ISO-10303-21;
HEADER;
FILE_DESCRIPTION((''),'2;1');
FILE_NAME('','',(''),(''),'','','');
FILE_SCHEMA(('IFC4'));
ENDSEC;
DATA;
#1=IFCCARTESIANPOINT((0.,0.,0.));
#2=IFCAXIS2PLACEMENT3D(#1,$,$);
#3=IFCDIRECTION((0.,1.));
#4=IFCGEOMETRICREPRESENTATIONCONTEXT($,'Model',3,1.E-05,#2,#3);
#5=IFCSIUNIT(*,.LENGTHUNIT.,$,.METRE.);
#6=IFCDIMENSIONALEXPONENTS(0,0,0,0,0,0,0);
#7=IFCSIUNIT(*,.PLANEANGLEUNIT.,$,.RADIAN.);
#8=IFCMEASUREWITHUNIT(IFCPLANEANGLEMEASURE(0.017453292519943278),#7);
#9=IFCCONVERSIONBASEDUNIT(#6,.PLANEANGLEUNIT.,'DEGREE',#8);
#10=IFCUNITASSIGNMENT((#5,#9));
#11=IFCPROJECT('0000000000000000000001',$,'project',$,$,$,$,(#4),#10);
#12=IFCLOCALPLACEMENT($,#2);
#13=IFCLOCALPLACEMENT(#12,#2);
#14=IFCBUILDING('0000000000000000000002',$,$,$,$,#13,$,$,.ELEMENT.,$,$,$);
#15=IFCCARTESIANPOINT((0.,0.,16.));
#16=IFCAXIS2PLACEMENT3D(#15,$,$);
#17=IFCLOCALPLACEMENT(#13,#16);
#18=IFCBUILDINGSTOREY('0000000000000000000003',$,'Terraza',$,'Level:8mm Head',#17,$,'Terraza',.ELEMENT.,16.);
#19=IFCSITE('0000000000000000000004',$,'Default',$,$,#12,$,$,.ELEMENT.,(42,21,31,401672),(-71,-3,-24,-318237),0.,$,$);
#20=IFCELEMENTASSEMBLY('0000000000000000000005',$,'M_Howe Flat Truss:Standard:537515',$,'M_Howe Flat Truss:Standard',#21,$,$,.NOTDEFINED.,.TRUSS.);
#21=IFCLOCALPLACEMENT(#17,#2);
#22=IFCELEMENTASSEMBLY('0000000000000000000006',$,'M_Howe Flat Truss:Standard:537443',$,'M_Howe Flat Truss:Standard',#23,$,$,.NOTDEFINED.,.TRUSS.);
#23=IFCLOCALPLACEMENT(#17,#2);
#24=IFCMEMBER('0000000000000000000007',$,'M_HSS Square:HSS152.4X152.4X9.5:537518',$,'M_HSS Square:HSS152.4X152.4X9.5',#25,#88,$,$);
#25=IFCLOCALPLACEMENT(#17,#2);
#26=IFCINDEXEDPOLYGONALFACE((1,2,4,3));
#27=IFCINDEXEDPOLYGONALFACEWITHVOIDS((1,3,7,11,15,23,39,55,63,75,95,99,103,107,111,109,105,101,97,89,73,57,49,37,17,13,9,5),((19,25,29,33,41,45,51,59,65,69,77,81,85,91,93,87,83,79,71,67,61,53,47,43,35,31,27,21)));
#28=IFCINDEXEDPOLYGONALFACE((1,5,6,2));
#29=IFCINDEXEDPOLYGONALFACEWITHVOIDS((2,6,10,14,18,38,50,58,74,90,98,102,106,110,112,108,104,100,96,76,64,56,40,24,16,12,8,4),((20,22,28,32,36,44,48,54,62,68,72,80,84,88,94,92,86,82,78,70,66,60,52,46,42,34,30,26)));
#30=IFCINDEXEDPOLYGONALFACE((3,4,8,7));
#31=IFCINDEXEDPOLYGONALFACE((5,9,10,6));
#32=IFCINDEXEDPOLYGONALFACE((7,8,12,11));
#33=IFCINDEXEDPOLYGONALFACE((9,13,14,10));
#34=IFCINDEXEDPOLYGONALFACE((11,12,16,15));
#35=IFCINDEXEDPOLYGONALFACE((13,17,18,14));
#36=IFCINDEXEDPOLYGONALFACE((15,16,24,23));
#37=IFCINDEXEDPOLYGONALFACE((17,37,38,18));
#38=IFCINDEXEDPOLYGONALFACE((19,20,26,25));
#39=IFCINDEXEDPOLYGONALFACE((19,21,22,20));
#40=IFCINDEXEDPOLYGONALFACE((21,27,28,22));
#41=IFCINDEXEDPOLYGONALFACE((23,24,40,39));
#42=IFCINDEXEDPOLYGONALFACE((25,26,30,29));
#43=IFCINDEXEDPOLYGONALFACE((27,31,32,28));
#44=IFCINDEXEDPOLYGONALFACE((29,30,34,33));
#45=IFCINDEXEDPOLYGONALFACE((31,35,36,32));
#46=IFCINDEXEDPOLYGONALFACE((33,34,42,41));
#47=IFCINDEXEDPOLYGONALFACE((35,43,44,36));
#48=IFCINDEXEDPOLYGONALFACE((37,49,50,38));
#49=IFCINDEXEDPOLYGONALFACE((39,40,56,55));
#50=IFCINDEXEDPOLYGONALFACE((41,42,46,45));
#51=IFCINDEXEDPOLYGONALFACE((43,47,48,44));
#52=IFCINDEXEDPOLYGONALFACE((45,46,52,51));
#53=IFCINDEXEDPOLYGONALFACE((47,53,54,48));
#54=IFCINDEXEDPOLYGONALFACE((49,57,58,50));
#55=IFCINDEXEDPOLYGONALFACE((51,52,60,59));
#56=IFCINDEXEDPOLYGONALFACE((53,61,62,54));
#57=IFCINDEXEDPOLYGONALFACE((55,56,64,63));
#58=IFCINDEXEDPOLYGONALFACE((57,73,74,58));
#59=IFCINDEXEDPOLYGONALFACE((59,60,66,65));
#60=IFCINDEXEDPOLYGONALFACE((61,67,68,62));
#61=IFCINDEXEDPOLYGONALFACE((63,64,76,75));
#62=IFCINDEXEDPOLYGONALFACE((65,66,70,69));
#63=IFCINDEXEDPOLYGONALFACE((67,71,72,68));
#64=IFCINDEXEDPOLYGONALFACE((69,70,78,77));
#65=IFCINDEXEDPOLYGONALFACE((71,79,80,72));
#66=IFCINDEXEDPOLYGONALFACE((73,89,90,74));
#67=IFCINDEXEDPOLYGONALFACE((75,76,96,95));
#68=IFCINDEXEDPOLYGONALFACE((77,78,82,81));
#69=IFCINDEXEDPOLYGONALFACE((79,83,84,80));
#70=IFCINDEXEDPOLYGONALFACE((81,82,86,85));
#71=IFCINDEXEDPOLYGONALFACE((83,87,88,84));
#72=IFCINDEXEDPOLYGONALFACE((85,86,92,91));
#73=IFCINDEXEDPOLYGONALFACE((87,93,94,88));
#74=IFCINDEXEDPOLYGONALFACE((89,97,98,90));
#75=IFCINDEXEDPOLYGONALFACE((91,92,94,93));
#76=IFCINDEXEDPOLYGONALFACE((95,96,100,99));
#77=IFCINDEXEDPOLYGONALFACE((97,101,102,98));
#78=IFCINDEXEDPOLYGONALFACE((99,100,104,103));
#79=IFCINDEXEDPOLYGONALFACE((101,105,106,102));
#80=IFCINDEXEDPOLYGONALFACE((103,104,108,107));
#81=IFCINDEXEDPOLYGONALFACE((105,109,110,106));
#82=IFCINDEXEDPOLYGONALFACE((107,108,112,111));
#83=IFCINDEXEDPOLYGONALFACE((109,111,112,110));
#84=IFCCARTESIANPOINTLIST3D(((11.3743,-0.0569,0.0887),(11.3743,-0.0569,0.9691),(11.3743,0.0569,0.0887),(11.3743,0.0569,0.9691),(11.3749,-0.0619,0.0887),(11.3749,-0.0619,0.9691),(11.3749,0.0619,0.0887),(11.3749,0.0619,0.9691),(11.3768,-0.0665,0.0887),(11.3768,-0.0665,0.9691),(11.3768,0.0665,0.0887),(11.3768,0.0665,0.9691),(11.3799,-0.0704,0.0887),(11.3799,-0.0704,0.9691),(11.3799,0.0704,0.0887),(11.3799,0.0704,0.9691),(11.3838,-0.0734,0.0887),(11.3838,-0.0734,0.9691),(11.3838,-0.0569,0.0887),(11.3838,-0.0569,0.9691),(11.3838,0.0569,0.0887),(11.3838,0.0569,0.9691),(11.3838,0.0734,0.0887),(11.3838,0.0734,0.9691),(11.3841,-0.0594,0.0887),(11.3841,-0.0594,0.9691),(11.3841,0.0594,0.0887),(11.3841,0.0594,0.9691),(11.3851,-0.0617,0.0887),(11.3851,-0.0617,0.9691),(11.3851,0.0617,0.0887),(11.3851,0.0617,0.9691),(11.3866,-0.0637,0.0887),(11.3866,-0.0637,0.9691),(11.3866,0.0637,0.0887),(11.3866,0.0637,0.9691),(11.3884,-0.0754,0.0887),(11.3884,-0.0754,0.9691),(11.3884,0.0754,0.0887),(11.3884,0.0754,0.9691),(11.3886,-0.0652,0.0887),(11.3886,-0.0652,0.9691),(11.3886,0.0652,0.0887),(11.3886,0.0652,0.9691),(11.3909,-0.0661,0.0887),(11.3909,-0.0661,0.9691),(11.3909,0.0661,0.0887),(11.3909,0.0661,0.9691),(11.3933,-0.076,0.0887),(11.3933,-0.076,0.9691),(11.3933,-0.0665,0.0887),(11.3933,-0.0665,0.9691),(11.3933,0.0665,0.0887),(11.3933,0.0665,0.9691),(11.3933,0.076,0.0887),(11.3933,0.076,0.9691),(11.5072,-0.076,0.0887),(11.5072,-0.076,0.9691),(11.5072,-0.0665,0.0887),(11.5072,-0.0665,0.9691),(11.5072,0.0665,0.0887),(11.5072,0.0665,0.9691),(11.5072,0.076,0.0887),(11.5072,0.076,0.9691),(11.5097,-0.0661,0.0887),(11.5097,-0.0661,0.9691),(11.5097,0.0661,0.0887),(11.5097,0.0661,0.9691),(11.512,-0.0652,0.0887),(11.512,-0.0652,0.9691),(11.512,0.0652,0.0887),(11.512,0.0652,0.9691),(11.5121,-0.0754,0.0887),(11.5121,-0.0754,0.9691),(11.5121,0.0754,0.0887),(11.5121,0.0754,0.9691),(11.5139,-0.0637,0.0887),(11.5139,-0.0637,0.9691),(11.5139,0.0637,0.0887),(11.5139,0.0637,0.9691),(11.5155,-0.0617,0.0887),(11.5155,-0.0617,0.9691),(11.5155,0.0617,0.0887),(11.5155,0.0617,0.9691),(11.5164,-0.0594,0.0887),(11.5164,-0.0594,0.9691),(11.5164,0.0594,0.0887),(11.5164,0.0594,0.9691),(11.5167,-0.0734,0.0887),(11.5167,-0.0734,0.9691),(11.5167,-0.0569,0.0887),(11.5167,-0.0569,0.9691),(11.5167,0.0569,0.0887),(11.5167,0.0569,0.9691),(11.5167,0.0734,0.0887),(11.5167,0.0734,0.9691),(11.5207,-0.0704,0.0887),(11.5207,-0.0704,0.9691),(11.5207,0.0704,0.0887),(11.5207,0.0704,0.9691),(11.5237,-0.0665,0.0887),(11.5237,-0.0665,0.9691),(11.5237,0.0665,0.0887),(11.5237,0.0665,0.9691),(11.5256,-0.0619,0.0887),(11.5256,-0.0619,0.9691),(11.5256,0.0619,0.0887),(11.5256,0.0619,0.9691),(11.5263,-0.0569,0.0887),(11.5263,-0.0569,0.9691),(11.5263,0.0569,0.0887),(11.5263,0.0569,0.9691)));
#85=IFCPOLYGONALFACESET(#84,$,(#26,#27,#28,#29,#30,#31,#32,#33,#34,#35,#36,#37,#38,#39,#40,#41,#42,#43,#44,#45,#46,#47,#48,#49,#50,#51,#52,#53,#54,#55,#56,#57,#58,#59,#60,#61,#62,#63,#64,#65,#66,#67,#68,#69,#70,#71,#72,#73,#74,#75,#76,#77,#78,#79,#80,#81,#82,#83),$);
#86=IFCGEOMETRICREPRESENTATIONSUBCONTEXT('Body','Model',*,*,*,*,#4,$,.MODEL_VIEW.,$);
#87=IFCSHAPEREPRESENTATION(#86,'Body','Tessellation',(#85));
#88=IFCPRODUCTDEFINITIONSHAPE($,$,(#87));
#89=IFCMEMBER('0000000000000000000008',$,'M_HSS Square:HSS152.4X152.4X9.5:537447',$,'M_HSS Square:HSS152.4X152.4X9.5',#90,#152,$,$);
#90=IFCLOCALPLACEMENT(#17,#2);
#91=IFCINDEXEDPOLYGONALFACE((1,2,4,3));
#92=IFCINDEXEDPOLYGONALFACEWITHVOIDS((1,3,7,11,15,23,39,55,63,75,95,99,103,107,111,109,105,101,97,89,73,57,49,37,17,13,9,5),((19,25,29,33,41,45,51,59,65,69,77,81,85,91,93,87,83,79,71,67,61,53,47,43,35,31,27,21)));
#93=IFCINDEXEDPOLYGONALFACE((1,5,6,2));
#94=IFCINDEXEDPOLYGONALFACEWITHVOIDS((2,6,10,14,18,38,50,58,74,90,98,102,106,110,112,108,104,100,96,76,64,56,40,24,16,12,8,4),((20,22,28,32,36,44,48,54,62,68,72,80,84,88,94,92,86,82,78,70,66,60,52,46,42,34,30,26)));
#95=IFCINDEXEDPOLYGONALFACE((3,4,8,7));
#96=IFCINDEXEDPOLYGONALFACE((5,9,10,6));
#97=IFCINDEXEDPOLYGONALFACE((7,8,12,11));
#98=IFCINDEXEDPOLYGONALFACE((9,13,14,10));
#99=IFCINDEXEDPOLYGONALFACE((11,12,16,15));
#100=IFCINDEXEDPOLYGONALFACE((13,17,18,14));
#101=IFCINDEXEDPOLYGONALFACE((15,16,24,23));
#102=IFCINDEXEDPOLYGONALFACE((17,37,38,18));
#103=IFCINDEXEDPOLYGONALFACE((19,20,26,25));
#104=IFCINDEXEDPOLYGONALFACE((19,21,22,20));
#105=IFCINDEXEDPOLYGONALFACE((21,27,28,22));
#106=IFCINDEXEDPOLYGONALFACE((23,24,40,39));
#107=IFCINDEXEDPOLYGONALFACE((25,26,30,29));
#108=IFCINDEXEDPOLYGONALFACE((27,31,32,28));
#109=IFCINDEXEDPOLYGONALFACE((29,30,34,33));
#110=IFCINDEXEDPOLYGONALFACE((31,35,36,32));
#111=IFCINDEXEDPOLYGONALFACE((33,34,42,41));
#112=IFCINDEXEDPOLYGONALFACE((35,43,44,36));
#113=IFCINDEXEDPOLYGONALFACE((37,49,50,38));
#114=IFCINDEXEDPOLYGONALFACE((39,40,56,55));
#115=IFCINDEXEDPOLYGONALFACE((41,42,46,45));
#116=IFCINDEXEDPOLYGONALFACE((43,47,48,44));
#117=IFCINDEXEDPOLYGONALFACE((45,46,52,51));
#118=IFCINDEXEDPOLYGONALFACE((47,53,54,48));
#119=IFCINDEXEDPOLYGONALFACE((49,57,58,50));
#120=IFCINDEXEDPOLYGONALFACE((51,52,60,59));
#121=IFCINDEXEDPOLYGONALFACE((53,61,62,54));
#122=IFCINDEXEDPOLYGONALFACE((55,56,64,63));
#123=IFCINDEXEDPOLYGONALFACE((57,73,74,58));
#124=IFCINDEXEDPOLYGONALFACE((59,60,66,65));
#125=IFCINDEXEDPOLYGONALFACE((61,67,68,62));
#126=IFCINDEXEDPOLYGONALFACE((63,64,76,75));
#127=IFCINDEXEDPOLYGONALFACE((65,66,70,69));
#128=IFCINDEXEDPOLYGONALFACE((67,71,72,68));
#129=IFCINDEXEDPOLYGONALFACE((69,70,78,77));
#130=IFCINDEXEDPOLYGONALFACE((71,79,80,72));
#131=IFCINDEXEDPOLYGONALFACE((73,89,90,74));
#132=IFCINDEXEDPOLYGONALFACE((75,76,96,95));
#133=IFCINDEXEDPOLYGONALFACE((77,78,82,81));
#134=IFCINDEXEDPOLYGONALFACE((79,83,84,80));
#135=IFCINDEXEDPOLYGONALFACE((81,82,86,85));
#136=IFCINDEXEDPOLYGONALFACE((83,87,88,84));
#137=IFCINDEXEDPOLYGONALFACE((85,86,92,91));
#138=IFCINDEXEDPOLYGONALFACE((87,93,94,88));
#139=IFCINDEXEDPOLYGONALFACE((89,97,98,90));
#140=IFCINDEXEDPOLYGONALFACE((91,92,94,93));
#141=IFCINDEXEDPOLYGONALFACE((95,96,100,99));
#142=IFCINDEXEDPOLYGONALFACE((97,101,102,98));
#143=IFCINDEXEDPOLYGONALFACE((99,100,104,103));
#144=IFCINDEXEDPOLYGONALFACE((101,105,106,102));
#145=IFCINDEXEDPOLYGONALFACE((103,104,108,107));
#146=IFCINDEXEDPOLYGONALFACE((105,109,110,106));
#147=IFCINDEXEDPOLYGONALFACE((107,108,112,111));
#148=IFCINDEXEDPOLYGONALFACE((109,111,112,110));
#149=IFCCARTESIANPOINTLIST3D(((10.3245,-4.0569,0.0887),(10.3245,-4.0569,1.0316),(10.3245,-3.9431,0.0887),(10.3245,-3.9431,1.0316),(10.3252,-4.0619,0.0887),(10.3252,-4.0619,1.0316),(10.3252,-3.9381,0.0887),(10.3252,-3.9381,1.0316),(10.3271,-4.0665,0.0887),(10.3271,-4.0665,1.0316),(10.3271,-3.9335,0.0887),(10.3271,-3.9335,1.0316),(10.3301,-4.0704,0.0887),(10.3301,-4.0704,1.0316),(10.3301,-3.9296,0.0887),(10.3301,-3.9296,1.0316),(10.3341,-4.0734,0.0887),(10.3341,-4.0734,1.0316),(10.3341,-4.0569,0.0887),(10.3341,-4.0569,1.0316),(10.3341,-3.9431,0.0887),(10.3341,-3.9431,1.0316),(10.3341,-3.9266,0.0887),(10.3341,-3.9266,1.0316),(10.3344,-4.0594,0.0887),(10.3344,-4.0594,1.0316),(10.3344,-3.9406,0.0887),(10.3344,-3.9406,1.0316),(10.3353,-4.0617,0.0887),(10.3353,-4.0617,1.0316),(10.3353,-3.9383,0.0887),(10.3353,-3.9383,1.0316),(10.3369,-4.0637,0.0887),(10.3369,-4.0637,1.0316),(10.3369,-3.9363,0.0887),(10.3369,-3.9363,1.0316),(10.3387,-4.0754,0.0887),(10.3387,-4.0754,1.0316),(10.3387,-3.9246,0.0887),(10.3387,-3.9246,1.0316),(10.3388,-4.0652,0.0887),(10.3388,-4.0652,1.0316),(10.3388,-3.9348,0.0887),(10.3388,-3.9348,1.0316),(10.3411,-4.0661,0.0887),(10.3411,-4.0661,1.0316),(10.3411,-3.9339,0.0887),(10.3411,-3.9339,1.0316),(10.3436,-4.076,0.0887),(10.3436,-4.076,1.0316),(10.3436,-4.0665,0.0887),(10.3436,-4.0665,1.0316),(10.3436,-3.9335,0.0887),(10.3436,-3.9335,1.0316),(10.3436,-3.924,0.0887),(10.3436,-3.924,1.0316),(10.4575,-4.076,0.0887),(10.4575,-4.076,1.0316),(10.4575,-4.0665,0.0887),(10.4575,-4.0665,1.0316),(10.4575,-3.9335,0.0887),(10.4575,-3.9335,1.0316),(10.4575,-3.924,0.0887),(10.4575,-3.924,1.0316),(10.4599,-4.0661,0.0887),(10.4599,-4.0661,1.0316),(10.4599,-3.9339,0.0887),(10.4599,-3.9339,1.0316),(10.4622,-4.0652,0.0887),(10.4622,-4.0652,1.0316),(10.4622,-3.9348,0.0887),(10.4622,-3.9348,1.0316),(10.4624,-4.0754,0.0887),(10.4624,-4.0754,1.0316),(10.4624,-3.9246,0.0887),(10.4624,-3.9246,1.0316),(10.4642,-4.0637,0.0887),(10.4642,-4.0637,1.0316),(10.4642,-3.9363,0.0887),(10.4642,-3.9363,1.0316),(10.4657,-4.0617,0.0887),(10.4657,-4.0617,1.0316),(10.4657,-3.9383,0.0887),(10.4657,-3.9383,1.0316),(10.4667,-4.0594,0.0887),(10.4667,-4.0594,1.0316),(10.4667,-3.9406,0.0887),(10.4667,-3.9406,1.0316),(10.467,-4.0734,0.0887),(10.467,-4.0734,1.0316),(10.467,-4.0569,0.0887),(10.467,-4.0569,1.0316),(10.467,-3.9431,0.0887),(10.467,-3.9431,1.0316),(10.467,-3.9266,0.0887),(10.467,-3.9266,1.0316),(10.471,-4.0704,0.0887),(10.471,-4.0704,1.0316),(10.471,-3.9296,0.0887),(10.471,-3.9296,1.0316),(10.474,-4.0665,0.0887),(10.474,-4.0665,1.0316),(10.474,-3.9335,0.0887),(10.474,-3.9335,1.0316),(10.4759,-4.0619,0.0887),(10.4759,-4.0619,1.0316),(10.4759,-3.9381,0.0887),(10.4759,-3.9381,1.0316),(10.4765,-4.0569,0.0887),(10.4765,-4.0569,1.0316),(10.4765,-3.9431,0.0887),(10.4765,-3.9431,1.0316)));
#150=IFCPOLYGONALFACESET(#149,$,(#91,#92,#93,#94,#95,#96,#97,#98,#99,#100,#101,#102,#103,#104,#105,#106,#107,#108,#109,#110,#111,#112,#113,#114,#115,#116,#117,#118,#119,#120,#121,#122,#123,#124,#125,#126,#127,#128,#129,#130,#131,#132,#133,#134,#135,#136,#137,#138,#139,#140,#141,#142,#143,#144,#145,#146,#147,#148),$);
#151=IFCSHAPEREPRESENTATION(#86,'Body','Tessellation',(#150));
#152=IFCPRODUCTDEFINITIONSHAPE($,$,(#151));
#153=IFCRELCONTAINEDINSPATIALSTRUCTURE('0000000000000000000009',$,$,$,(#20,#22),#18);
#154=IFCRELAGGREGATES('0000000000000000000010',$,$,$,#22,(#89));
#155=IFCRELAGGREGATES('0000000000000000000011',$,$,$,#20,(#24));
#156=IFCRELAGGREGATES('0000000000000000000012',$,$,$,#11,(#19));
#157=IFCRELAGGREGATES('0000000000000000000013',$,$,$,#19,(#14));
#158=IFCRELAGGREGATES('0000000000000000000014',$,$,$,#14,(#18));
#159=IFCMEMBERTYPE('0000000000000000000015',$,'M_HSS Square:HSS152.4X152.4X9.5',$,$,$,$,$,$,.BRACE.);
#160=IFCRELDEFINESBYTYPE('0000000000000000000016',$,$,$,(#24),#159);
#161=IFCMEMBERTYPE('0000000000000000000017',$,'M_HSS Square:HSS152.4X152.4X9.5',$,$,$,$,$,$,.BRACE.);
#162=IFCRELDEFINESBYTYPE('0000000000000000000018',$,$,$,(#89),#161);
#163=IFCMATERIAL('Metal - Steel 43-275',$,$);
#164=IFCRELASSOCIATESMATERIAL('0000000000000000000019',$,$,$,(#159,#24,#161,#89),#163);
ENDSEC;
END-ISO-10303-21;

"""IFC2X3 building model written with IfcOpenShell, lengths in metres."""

from ifc_helpers import new_model, entity, si_unit, converted_unit, direction, frame, frame_2d, origin, place, context, subcontext, project, spatial, polyline, circle_curve, parameter, trimmed, segment, composite_curve, outline, extrude, source, transform, mapped, material, type_object, type_shapes, element, aggregate, save


model = new_model("IFC2X3")

# Units and contexts
model_context = context("Model", 3, precision=1e-05, world=origin(), true_north=direction((0.0, 1.0)))
body_context = subcontext(model_context, "Body", "Model", "MODEL_VIEW")
ifc_project = project(units=[si_unit("LENGTHUNIT", "METRE"), converted_unit("PLANEANGLEUNIT", "DEGREE", entity("IfcPlaneAngleMeasure", 0.017453292519943278), si_unit("PLANEANGLEUNIT", "RADIAN"), dimensions=[0, 0, 0, 0, 0, 0, 0])], contexts=[model_context])

# Site, building, storey
site_placement = place(None, origin())
site = spatial("IfcSite", under=ifc_project, at=site_placement, Name="Default", CompositionType="ELEMENT", RefLatitude=(42, 21, 31, 401672), RefLongitude=(-71, -3, -24, -318237), RefElevation=0.0)
building_placement = place(site_placement, origin())
building = spatial("IfcBuilding", under=site, at=building_placement, CompositionType="ELEMENT")
storey_placement = place(building_placement, frame((0.0, 0.0, 16.0)))
storey = spatial("IfcBuildingStorey", under=building, at=storey_placement, Name="Terraza", ObjectType="Level:8mm Head", LongName="Terraza", CompositionType="ELEMENT", Elevation=16.0)

# Element assemblies
assembly_1_placement = place(storey_placement, origin())
assembly_1 = element("IfcElementAssembly", 1, at=assembly_1_placement, inside=storey, Name="M_Howe Flat Truss:Standard:537515", ObjectType="M_Howe Flat Truss:Standard", AssemblyPlace="NOTDEFINED", PredefinedType="TRUSS")
ifc_material_1 = material(Name="Metal - Steel 43-275")
assembly_2_placement = place(storey_placement, origin())
assembly_2 = element("IfcElementAssembly", 2, at=assembly_2_placement, inside=storey, Name="M_Howe Flat Truss:Standard:537443", ObjectType="M_Howe Flat Truss:Standard", AssemblyPlace="NOTDEFINED", PredefinedType="TRUSS")
member_type_1 = type_object("IfcMemberType", Name="M_HSS Square:HSS152.4X152.4X9.5", PredefinedType="BRACE", material=ifc_material_1)
shared_shape_1 = source(origin(), body_context, "Body", "SweptSolid", [
    extrude(outline(composite_curve([segment(polyline([(-0.0569, -0.076), (0.0569, -0.076)]), True, "CONTINUOUS"), segment(trimmed(circle_curve(frame_2d((0.0569, -0.0569), x_axis=(0.0, 1.0)), 0.0191), [parameter(180.0)], [parameter(270.0)], True, "PARAMETER"), True, "CONTINUOUS"), segment(polyline([(0.076, -0.0569), (0.076, 0.0569)]), True, "CONTINUOUS"), segment(trimmed(circle_curve(frame_2d((0.0569, 0.0569), x_axis=(0.0, 1.0)), 0.0191), [parameter(270.0)], [parameter(0.0)], True, "PARAMETER"), True, "CONTINUOUS"), segment(polyline([(0.0569, 0.076), (-0.0569, 0.076)]), True, "CONTINUOUS"), segment(trimmed(circle_curve(frame_2d((-0.0569, 0.0569), x_axis=(0.0, 1.0)), 0.0191), [parameter(0.0)], [parameter(90.0)], True, "PARAMETER"), True, "CONTINUOUS"), segment(polyline([(-0.076, 0.0569), (-0.076, -0.0569)]), True, "CONTINUOUS"), segment(trimmed(circle_curve(frame_2d((-0.0569, -0.0569), x_axis=(0.0, 1.0)), 0.0191), [parameter(90.0)], [parameter(180.0)], True, "PARAMETER"), True, "CONTINUOUS")], self_intersect=False), holes=[composite_curve([segment(trimmed(circle_curve(frame_2d((-0.0569, 0.0569), x_axis=(0.0, 1.0)), 0.0095), [parameter(360.0)], [parameter(90.0)], True, "PARAMETER"), False, "CONTINUOUS"), segment(polyline([(-0.0569, 0.0665), (0.0569, 0.0665)]), True, "CONTINUOUS"), segment(trimmed(circle_curve(frame_2d((0.0569, 0.0569), x_axis=(0.0, 1.0)), 0.0095), [parameter(270.0)], [parameter(360.0)], True, "PARAMETER"), False, "CONTINUOUS"), segment(polyline([(0.0665, 0.0569), (0.0665, -0.0569)]), True, "CONTINUOUS"), segment(trimmed(circle_curve(frame_2d((0.0569, -0.0569), x_axis=(0.0, 1.0)), 0.0095), [parameter(180.0)], [parameter(270.0)], True, "PARAMETER"), False, "CONTINUOUS"), segment(polyline([(0.0569, -0.0665), (-0.0569, -0.0665)]), True, "CONTINUOUS"), segment(trimmed(circle_curve(frame_2d((-0.0569, -0.0569), x_axis=(0.0, 1.0)), 0.0095), [parameter(90.0)], [parameter(180.0)], True, "PARAMETER"), False, "CONTINUOUS"), segment(polyline([(-0.0665, -0.0569), (-0.0665, 0.0569)]), True, "CONTINUOUS")], self_intersect=False)]), frame((-0.4426, 0.0, 0.0), z_axis=(1.0, 0.0, 0.0), x_axis=(0.0, 0.0, -1.0)), (0.0, 0.0, 1.0), 0.8804),
])
type_shapes(member_type_1, [shared_shape_1])

# Members
member_1_placement = place(assembly_1_placement, frame((11.4503, 0.0, 0.5312), z_axis=(1.0, 0.0, 0.0), x_axis=(0.0, 0.0, 1.0)))
member_1 = element("IfcMember", 3, at=member_1_placement, type_object=member_type_1, material=ifc_material_1, Name="M_HSS Square:HSS152.4X152.4X9.5:537518", ObjectType="M_HSS Square:HSS152.4X152.4X9.5", context=body_context, shape_type="MappedRepresentation", body=[
    mapped(shared_shape_1, transform((0.0, 0.0, 0.0), scale=1.0)),
])
member_type_2 = type_object("IfcMemberType", Name="M_HSS Square:HSS152.4X152.4X9.5", PredefinedType="BRACE", material=ifc_material_1)
shared_shape_2 = source(origin(), body_context, "Body", "SweptSolid", [
    extrude(outline(composite_curve([segment(polyline([(-0.0569, -0.076), (0.0569, -0.076)]), True, "CONTINUOUS"), segment(trimmed(circle_curve(frame_2d((0.0569, -0.0569), x_axis=(0.0, 1.0)), 0.0191), [parameter(180.0)], [parameter(270.0)], True, "PARAMETER"), True, "CONTINUOUS"), segment(polyline([(0.076, -0.0569), (0.076, 0.0569)]), True, "CONTINUOUS"), segment(trimmed(circle_curve(frame_2d((0.0569, 0.0569), x_axis=(0.0, 1.0)), 0.0191), [parameter(270.0)], [parameter(0.0)], True, "PARAMETER"), True, "CONTINUOUS"), segment(polyline([(0.0569, 0.076), (-0.0569, 0.076)]), True, "CONTINUOUS"), segment(trimmed(circle_curve(frame_2d((-0.0569, 0.0569), x_axis=(0.0, 1.0)), 0.0191), [parameter(0.0)], [parameter(90.0)], True, "PARAMETER"), True, "CONTINUOUS"), segment(polyline([(-0.076, 0.0569), (-0.076, -0.0569)]), True, "CONTINUOUS"), segment(trimmed(circle_curve(frame_2d((-0.0569, -0.0569), x_axis=(0.0, 1.0)), 0.0191), [parameter(90.0)], [parameter(180.0)], True, "PARAMETER"), True, "CONTINUOUS")], self_intersect=False), holes=[composite_curve([segment(trimmed(circle_curve(frame_2d((-0.0569, 0.0569), x_axis=(0.0, 1.0)), 0.0095), [parameter(360.0)], [parameter(90.0)], True, "PARAMETER"), False, "CONTINUOUS"), segment(polyline([(-0.0569, 0.0665), (0.0569, 0.0665)]), True, "CONTINUOUS"), segment(trimmed(circle_curve(frame_2d((0.0569, 0.0569), x_axis=(0.0, 1.0)), 0.0095), [parameter(270.0)], [parameter(360.0)], True, "PARAMETER"), False, "CONTINUOUS"), segment(polyline([(0.0665, 0.0569), (0.0665, -0.0569)]), True, "CONTINUOUS"), segment(trimmed(circle_curve(frame_2d((0.0569, -0.0569), x_axis=(0.0, 1.0)), 0.0095), [parameter(180.0)], [parameter(270.0)], True, "PARAMETER"), False, "CONTINUOUS"), segment(polyline([(0.0569, -0.0665), (-0.0569, -0.0665)]), True, "CONTINUOUS"), segment(trimmed(circle_curve(frame_2d((-0.0569, -0.0569), x_axis=(0.0, 1.0)), 0.0095), [parameter(90.0)], [parameter(180.0)], True, "PARAMETER"), False, "CONTINUOUS"), segment(polyline([(-0.0665, -0.0569), (-0.0665, 0.0569)]), True, "CONTINUOUS")], self_intersect=False)]), frame((-0.4738, 0.0, 0.0), z_axis=(1.0, 0.0, 0.0), x_axis=(0.0, 0.0, -1.0)), (0.0, 0.0, 1.0), 0.9429),
])
type_shapes(member_type_2, [shared_shape_2])
member_2_placement = place(assembly_2_placement, frame((10.4005, -4.0, 0.5625), z_axis=(1.0, 0.0, 0.0), x_axis=(0.0, 0.0, 1.0)))
member_2 = element("IfcMember", 4, at=member_2_placement, type_object=member_type_2, material=ifc_material_1, Name="M_HSS Square:HSS152.4X152.4X9.5:537447", ObjectType="M_HSS Square:HSS152.4X152.4X9.5", context=body_context, shape_type="MappedRepresentation", body=[
    mapped(shared_shape_2, transform((0.0, 0.0, 0.0), scale=1.0)),
])
aggregate(assembly_2, [member_2])
aggregate(assembly_1, [member_1])

save(model, "model.ifc")
